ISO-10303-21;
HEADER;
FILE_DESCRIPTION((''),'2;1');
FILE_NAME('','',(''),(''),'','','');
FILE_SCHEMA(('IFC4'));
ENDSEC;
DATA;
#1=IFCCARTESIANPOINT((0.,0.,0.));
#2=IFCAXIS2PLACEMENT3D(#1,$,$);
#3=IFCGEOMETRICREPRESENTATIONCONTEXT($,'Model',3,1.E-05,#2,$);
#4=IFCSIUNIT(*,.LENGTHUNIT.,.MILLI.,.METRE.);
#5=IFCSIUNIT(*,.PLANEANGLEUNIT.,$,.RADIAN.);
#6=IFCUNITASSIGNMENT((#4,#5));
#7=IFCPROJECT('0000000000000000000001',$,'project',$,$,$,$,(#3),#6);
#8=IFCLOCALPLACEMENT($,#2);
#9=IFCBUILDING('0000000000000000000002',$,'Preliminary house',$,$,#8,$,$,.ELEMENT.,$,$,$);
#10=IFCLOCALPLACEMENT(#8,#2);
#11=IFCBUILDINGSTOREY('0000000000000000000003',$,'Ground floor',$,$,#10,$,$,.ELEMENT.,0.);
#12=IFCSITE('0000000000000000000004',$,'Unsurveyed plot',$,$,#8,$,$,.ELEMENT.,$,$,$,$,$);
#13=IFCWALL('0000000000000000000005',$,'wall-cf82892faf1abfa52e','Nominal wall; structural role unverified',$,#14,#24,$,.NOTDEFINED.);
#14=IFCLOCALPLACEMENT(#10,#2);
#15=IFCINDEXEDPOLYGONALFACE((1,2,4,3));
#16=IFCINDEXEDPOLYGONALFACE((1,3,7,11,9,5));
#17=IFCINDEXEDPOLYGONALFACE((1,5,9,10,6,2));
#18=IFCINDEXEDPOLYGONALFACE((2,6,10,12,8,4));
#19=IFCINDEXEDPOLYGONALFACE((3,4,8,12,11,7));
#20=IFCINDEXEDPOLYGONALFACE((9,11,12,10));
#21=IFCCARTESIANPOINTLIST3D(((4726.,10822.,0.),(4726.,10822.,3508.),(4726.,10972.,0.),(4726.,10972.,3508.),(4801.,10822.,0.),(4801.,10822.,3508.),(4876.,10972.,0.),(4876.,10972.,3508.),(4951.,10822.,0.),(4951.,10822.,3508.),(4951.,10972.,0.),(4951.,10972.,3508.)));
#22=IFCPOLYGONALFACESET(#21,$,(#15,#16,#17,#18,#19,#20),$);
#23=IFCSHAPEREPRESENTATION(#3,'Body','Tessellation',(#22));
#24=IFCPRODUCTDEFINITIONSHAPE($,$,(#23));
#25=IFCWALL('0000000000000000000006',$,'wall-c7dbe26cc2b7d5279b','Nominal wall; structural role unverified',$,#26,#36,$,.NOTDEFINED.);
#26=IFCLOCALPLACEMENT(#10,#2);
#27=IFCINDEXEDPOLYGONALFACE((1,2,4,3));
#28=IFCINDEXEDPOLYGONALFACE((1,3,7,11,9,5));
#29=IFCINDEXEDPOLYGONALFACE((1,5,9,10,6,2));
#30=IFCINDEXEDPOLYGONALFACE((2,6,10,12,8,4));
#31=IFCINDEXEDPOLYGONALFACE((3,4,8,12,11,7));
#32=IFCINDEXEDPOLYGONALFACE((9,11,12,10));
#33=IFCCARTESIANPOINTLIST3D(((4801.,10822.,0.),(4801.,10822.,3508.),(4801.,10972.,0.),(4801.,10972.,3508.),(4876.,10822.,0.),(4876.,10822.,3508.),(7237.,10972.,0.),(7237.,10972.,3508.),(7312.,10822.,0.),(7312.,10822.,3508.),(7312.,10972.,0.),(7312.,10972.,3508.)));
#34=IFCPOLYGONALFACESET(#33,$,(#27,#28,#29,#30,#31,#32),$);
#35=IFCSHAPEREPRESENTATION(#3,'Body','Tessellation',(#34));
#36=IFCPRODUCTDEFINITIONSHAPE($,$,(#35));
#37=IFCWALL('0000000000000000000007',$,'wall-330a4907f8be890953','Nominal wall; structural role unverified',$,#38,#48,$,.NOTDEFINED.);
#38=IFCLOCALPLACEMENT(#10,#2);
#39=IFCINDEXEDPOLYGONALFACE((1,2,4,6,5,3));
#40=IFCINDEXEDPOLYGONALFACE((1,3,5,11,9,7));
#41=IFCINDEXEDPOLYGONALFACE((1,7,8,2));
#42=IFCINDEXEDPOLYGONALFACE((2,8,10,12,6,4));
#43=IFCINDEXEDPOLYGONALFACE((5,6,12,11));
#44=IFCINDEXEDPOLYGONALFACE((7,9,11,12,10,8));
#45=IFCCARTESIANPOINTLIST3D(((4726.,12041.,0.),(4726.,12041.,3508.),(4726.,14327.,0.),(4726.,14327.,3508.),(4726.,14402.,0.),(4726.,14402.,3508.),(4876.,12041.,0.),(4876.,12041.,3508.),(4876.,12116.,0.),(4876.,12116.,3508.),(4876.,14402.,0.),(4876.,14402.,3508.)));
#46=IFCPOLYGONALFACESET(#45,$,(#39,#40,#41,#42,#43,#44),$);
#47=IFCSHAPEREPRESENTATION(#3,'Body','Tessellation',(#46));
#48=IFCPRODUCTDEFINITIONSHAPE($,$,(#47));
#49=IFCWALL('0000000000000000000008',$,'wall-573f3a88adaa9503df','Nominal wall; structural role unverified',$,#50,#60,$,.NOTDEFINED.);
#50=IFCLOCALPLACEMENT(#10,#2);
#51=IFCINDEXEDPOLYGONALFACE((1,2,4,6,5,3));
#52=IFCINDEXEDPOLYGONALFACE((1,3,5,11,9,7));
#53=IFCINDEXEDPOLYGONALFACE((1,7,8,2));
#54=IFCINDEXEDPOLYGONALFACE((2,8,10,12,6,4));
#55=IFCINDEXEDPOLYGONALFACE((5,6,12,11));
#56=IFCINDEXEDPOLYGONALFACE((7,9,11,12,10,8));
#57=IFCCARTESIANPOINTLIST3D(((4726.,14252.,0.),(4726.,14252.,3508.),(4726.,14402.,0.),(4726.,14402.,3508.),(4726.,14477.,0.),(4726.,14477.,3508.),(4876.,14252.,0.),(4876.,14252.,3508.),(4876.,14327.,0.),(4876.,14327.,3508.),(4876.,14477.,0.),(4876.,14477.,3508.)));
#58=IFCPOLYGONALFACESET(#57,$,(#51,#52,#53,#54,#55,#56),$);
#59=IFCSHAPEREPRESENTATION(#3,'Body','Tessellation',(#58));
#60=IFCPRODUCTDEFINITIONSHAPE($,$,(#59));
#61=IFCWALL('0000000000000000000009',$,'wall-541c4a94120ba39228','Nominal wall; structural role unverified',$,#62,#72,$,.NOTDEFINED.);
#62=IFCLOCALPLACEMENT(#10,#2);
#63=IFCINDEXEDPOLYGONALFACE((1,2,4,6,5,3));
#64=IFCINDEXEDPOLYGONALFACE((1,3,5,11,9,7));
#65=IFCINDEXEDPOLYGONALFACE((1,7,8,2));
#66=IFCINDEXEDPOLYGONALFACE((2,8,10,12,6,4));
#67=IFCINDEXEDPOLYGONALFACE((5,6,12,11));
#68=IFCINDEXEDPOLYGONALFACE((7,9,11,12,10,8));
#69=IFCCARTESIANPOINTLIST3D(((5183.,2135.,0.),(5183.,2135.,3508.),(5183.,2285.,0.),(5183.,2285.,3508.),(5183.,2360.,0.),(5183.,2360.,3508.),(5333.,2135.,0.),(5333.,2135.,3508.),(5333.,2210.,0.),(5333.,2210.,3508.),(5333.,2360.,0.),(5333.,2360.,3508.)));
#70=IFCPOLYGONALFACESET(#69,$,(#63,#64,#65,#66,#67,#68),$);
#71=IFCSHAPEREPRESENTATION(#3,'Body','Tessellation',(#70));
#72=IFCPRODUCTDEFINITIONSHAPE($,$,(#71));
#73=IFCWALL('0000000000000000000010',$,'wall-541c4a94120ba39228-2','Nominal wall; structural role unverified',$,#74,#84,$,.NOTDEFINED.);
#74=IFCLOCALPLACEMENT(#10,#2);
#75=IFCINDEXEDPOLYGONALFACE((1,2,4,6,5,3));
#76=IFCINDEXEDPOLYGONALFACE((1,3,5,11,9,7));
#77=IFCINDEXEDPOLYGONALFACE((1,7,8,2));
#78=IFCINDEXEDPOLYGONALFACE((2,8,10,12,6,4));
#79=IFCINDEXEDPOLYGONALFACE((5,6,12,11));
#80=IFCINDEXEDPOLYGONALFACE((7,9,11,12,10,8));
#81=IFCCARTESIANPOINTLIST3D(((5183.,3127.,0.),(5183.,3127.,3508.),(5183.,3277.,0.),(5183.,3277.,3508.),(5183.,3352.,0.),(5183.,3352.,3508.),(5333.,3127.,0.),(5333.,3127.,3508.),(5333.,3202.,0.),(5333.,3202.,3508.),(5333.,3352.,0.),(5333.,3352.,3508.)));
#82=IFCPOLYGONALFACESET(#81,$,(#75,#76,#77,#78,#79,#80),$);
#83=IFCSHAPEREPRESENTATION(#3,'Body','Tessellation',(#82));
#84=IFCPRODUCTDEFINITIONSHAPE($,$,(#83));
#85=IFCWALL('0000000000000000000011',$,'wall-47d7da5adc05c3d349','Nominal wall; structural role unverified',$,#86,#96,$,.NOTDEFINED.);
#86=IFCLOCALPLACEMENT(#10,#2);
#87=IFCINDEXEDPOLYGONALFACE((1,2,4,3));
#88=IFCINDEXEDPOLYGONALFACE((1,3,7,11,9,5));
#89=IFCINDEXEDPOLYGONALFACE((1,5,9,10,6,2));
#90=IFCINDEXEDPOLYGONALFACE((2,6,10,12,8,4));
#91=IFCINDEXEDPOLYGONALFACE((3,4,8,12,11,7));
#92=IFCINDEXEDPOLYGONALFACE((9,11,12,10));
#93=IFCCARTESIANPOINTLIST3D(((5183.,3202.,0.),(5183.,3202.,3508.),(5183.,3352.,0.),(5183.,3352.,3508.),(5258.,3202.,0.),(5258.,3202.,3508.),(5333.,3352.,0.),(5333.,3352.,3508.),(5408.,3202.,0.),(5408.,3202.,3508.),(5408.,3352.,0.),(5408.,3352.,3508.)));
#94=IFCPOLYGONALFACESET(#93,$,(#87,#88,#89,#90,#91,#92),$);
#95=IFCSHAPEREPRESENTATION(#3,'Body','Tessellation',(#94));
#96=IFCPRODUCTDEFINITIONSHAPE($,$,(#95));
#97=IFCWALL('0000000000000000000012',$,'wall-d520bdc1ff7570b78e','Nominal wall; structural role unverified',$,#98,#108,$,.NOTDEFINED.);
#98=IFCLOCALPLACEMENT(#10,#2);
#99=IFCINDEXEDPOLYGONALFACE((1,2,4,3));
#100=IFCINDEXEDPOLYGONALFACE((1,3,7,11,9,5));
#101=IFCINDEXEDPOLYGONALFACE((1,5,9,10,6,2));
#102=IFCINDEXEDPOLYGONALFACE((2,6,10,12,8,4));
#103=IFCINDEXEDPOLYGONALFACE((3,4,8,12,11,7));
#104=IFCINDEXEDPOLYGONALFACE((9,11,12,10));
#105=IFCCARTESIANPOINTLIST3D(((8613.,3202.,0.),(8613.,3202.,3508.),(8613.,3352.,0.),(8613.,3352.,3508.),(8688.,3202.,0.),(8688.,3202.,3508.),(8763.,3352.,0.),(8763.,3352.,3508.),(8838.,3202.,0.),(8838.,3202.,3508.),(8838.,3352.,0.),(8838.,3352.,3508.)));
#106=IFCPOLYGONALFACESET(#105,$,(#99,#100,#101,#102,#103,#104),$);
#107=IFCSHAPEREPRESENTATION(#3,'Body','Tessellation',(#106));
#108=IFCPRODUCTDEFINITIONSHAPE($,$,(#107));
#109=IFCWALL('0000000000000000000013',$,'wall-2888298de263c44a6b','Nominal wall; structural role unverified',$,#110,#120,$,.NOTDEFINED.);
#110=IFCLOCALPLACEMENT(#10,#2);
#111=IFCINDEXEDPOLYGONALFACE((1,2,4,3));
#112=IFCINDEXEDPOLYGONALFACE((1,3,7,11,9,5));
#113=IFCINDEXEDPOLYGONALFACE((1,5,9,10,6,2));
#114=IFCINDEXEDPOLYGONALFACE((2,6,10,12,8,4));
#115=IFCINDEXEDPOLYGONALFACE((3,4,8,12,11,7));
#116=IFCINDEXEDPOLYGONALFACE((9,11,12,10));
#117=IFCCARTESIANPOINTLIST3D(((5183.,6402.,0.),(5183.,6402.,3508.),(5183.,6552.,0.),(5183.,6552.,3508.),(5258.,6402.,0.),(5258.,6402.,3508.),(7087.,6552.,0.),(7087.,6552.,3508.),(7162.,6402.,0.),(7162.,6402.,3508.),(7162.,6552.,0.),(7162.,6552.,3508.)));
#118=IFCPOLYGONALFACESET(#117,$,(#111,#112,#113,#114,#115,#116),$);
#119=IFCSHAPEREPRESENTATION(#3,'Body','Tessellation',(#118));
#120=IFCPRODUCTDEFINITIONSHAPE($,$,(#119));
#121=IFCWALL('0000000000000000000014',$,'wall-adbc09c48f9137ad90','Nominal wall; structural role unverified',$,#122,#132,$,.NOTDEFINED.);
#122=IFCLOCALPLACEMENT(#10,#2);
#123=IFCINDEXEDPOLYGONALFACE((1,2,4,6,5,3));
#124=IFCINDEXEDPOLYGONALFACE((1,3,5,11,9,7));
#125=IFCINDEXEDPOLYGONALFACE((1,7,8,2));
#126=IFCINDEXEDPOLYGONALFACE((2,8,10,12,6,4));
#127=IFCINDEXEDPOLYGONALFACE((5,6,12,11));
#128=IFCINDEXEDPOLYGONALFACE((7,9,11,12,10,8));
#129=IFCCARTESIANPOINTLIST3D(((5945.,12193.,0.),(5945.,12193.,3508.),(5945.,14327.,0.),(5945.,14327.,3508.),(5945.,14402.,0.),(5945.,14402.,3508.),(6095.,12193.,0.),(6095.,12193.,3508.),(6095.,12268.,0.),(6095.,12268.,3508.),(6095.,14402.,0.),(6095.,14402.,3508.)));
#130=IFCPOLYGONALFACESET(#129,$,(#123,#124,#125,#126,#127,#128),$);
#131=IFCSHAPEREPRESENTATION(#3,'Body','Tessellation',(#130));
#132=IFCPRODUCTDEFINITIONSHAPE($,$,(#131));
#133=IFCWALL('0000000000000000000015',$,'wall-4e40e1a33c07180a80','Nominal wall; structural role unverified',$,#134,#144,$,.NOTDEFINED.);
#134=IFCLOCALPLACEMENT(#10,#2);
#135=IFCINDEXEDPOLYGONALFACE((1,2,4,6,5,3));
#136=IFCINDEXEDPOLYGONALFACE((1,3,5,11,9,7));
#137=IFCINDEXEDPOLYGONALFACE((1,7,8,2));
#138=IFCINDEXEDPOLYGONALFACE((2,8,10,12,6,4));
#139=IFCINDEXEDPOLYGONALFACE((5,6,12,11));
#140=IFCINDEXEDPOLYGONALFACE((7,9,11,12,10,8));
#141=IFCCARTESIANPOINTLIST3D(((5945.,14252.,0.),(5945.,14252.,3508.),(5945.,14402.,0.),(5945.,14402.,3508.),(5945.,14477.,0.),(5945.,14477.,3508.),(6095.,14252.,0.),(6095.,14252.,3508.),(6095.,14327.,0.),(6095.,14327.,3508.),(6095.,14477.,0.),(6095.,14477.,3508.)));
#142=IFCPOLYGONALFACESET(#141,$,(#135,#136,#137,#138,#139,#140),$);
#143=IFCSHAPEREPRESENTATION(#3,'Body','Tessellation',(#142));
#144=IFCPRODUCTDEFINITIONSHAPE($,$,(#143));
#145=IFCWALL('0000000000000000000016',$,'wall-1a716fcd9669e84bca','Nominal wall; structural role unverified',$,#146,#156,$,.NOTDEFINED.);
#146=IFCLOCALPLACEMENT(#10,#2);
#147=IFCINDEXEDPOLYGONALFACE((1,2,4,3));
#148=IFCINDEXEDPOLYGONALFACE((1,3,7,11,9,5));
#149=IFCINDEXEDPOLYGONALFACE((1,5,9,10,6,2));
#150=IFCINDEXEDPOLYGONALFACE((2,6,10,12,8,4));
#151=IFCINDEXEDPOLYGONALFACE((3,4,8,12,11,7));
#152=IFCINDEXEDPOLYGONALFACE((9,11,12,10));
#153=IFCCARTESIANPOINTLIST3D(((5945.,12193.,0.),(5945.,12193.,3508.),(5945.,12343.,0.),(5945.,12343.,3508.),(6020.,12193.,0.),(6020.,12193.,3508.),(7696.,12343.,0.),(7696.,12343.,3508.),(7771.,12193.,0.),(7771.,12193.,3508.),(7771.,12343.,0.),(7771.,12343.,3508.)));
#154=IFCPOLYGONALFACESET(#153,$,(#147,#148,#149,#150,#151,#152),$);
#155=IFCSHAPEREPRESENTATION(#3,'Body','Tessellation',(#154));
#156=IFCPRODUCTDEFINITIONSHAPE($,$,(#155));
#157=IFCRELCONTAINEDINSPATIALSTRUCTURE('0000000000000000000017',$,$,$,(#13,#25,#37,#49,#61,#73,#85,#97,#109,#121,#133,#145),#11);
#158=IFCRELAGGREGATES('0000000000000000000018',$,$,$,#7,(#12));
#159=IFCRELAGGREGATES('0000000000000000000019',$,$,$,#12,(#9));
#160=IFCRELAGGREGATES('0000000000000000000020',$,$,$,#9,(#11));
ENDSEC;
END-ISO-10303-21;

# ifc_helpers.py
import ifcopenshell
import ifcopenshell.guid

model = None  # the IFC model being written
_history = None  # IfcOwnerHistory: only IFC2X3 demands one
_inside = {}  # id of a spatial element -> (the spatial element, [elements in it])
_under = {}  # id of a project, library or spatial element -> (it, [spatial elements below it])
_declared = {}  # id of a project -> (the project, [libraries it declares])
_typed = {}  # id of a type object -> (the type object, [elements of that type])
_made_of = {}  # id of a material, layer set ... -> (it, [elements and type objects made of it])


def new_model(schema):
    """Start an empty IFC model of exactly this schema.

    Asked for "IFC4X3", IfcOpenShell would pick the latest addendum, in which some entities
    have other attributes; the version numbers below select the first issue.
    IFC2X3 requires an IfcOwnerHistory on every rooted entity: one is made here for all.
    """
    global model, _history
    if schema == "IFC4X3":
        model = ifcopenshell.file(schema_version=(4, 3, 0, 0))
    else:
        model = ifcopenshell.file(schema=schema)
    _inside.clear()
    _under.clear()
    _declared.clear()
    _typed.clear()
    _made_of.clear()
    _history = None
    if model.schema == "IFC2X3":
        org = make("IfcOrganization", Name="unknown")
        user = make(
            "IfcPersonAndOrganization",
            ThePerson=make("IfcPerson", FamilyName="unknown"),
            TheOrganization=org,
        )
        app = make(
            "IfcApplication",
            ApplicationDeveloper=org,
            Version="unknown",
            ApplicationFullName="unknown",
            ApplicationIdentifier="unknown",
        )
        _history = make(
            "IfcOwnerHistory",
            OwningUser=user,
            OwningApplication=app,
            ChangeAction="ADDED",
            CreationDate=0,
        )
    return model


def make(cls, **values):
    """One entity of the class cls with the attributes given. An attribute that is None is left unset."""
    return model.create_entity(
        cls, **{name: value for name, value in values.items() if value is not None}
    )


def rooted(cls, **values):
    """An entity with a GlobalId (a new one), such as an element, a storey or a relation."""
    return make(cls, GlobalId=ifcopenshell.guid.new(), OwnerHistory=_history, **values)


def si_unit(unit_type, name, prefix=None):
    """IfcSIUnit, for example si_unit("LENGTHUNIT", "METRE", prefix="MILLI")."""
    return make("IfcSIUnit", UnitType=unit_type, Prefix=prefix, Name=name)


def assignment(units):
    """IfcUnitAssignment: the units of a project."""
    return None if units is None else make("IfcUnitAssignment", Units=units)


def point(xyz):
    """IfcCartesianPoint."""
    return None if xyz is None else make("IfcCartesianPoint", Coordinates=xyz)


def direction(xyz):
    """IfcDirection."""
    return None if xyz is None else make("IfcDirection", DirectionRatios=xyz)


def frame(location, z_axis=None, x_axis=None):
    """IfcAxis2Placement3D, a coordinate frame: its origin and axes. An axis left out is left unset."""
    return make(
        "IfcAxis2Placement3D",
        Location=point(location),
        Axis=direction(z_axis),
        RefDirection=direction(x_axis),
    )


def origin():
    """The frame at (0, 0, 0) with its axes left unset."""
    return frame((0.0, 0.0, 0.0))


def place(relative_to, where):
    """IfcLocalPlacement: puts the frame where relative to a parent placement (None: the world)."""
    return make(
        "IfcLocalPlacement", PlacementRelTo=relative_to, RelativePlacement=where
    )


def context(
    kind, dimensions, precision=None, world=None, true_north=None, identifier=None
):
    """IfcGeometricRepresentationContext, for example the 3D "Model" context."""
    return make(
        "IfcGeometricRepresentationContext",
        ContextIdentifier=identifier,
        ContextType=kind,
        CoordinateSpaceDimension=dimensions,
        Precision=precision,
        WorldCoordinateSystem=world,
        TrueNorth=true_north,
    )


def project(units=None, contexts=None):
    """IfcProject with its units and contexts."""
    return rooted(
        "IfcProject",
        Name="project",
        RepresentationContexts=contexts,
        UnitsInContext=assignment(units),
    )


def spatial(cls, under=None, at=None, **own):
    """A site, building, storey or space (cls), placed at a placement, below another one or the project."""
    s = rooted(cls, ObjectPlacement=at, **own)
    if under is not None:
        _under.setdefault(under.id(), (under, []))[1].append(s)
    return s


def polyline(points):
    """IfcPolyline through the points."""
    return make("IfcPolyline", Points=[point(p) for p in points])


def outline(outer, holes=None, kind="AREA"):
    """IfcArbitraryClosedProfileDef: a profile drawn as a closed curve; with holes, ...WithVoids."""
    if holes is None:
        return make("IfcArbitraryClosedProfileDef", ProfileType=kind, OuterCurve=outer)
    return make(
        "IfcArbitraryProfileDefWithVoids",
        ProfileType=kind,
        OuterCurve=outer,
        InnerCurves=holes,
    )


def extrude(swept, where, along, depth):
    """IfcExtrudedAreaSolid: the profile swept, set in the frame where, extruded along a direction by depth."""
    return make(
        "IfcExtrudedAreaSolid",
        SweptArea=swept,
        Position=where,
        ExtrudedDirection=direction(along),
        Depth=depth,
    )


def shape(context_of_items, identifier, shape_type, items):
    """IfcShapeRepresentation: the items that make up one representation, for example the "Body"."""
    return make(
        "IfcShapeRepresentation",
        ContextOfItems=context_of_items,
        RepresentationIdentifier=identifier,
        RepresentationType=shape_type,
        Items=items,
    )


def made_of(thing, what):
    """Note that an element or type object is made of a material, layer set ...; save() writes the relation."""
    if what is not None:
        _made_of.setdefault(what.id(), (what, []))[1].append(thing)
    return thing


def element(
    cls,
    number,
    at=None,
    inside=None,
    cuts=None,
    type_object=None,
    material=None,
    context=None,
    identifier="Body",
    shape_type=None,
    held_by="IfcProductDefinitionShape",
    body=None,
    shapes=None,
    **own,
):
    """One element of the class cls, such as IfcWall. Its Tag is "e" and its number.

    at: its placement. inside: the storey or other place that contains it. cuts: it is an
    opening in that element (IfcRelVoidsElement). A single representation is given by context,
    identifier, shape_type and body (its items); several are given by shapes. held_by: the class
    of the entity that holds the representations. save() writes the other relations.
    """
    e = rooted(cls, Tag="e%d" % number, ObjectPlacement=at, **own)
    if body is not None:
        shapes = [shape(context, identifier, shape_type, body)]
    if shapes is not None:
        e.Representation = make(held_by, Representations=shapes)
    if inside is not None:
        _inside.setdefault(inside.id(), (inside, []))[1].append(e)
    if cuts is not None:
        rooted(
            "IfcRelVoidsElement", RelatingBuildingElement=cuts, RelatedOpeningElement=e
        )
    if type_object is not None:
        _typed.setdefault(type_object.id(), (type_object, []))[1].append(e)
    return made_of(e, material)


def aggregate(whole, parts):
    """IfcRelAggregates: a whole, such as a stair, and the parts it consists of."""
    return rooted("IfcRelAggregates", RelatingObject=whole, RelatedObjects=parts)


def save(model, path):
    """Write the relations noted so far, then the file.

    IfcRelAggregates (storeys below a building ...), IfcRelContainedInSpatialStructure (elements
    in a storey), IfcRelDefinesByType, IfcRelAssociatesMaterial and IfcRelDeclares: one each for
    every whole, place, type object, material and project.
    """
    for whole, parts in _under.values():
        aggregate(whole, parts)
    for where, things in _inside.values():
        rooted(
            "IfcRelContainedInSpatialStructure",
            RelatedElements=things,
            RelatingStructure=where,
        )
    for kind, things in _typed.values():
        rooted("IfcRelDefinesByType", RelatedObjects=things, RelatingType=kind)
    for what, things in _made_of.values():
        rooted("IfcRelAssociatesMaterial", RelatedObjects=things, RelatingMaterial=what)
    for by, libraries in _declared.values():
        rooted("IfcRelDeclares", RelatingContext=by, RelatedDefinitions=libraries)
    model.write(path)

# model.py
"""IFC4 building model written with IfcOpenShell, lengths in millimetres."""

from ifc_helpers import new_model, si_unit, origin, place, context, project, spatial, polyline, outline, extrude, element, save


model = new_model("IFC4")

# Units and contexts
model_context = context("Model", 3, precision=1e-05, world=origin())
ifc_project = project(units=[si_unit("LENGTHUNIT", "METRE", prefix="MILLI"), si_unit("PLANEANGLEUNIT", "RADIAN")], contexts=[model_context])

# Site, building, storey
placement_1 = place(None, origin())
site = spatial("IfcSite", under=ifc_project, at=placement_1, Name="Unsurveyed plot", CompositionType="ELEMENT")
building = spatial("IfcBuilding", under=site, at=placement_1, Name="Preliminary house", CompositionType="ELEMENT")
placement_2 = place(placement_1, origin())
storey = spatial("IfcBuildingStorey", under=building, at=placement_2, Name="Ground floor", CompositionType="ELEMENT", Elevation=0.0)

# Walls
element("IfcWall", 1, at=placement_2, inside=storey, Name="wall-cf82892faf1abfa52e", Description="Nominal wall; structural role unverified", PredefinedType="NOTDEFINED", context=model_context, shape_type="SweptSolid", body=[
    extrude(outline(polyline([(4876.0, 10972.0), (4951.0, 10972.0), (4951.0, 10822.0), (4801.0, 10822.0), (4726.0, 10822.0), (4726.0, 10972.0), (4876.0, 10972.0)])), origin(), (0.0, 0.0, 1.0), 3508.0),
])
element("IfcWall", 2, at=placement_2, inside=storey, Name="wall-c7dbe26cc2b7d5279b", Description="Nominal wall; structural role unverified", PredefinedType="NOTDEFINED", context=model_context, shape_type="SweptSolid", body=[
    extrude(outline(polyline([(7237.0, 10972.0), (7312.0, 10972.0), (7312.0, 10822.0), (4876.0, 10822.0), (4801.0, 10822.0), (4801.0, 10972.0), (7237.0, 10972.0)])), origin(), (0.0, 0.0, 1.0), 3508.0),
])
element("IfcWall", 3, at=placement_2, inside=storey, Name="wall-330a4907f8be890953", Description="Nominal wall; structural role unverified", PredefinedType="NOTDEFINED", context=model_context, shape_type="SweptSolid", body=[
    extrude(outline(polyline([(4726.0, 14327.0), (4726.0, 14402.0), (4876.0, 14402.0), (4876.0, 12116.0), (4876.0, 12041.0), (4726.0, 12041.0), (4726.0, 14327.0)])), origin(), (0.0, 0.0, 1.0), 3508.0),
])
element("IfcWall", 4, at=placement_2, inside=storey, Name="wall-573f3a88adaa9503df", Description="Nominal wall; structural role unverified", PredefinedType="NOTDEFINED", context=model_context, shape_type="SweptSolid", body=[
    extrude(outline(polyline([(4726.0, 14402.0), (4726.0, 14477.0), (4876.0, 14477.0), (4876.0, 14327.0), (4876.0, 14252.0), (4726.0, 14252.0), (4726.0, 14402.0)])), origin(), (0.0, 0.0, 1.0), 3508.0),
])
element("IfcWall", 5, at=placement_2, inside=storey, Name="wall-541c4a94120ba39228", Description="Nominal wall; structural role unverified", PredefinedType="NOTDEFINED", context=model_context, shape_type="SweptSolid", body=[
    extrude(outline(polyline([(5183.0, 2285.0), (5183.0, 2360.0), (5333.0, 2360.0), (5333.0, 2210.0), (5333.0, 2135.0), (5183.0, 2135.0), (5183.0, 2285.0)])), origin(), (0.0, 0.0, 1.0), 3508.0),
])

# Wall
element("IfcWall", 6, at=placement_2, inside=storey, Name="wall-541c4a94120ba39228-2", Description="Nominal wall; structural role unverified", PredefinedType="NOTDEFINED", context=model_context, shape_type="SweptSolid", body=[
    extrude(outline(polyline([(5183.0, 3277.0), (5183.0, 3352.0), (5333.0, 3352.0), (5333.0, 3202.0), (5333.0, 3127.0), (5183.0, 3127.0), (5183.0, 3277.0)])), origin(), (0.0, 0.0, 1.0), 3508.0),
])

# Wall
element("IfcWall", 7, at=placement_2, inside=storey, Name="wall-47d7da5adc05c3d349", Description="Nominal wall; structural role unverified", PredefinedType="NOTDEFINED", context=model_context, shape_type="SweptSolid", body=[
    extrude(outline(polyline([(5333.0, 3352.0), (5408.0, 3352.0), (5408.0, 3202.0), (5258.0, 3202.0), (5183.0, 3202.0), (5183.0, 3352.0), (5333.0, 3352.0)])), origin(), (0.0, 0.0, 1.0), 3508.0),
])

# Walls
element("IfcWall", 8, at=placement_2, inside=storey, Name="wall-d520bdc1ff7570b78e", Description="Nominal wall; structural role unverified", PredefinedType="NOTDEFINED", context=model_context, shape_type="SweptSolid", body=[
    extrude(outline(polyline([(8763.0, 3352.0), (8838.0, 3352.0), (8838.0, 3202.0), (8688.0, 3202.0), (8613.0, 3202.0), (8613.0, 3352.0), (8763.0, 3352.0)])), origin(), (0.0, 0.0, 1.0), 3508.0),
])
element("IfcWall", 9, at=placement_2, inside=storey, Name="wall-2888298de263c44a6b", Description="Nominal wall; structural role unverified", PredefinedType="NOTDEFINED", context=model_context, shape_type="SweptSolid", body=[
    extrude(outline(polyline([(7087.0, 6552.0), (7162.0, 6552.0), (7162.0, 6402.0), (5258.0, 6402.0), (5183.0, 6402.0), (5183.0, 6552.0), (7087.0, 6552.0)])), origin(), (0.0, 0.0, 1.0), 3508.0),
])
element("IfcWall", 10, at=placement_2, inside=storey, Name="wall-adbc09c48f9137ad90", Description="Nominal wall; structural role unverified", PredefinedType="NOTDEFINED", context=model_context, shape_type="SweptSolid", body=[
    extrude(outline(polyline([(5945.0, 14327.0), (5945.0, 14402.0), (6095.0, 14402.0), (6095.0, 12268.0), (6095.0, 12193.0), (5945.0, 12193.0), (5945.0, 14327.0)])), origin(), (0.0, 0.0, 1.0), 3508.0),
])
element("IfcWall", 11, at=placement_2, inside=storey, Name="wall-4e40e1a33c07180a80", Description="Nominal wall; structural role unverified", PredefinedType="NOTDEFINED", context=model_context, shape_type="SweptSolid", body=[
    extrude(outline(polyline([(5945.0, 14402.0), (5945.0, 14477.0), (6095.0, 14477.0), (6095.0, 14327.0), (6095.0, 14252.0), (5945.0, 14252.0), (5945.0, 14402.0)])), origin(), (0.0, 0.0, 1.0), 3508.0),
])
element("IfcWall", 12, at=placement_2, inside=storey, Name="wall-1a716fcd9669e84bca", Description="Nominal wall; structural role unverified", PredefinedType="NOTDEFINED", context=model_context, shape_type="SweptSolid", body=[
    extrude(outline(polyline([(7696.0, 12343.0), (7771.0, 12343.0), (7771.0, 12193.0), (6020.0, 12193.0), (5945.0, 12193.0), (5945.0, 12343.0), (7696.0, 12343.0)])), origin(), (0.0, 0.0, 1.0), 3508.0),
])

save(model, "model.ifc")
